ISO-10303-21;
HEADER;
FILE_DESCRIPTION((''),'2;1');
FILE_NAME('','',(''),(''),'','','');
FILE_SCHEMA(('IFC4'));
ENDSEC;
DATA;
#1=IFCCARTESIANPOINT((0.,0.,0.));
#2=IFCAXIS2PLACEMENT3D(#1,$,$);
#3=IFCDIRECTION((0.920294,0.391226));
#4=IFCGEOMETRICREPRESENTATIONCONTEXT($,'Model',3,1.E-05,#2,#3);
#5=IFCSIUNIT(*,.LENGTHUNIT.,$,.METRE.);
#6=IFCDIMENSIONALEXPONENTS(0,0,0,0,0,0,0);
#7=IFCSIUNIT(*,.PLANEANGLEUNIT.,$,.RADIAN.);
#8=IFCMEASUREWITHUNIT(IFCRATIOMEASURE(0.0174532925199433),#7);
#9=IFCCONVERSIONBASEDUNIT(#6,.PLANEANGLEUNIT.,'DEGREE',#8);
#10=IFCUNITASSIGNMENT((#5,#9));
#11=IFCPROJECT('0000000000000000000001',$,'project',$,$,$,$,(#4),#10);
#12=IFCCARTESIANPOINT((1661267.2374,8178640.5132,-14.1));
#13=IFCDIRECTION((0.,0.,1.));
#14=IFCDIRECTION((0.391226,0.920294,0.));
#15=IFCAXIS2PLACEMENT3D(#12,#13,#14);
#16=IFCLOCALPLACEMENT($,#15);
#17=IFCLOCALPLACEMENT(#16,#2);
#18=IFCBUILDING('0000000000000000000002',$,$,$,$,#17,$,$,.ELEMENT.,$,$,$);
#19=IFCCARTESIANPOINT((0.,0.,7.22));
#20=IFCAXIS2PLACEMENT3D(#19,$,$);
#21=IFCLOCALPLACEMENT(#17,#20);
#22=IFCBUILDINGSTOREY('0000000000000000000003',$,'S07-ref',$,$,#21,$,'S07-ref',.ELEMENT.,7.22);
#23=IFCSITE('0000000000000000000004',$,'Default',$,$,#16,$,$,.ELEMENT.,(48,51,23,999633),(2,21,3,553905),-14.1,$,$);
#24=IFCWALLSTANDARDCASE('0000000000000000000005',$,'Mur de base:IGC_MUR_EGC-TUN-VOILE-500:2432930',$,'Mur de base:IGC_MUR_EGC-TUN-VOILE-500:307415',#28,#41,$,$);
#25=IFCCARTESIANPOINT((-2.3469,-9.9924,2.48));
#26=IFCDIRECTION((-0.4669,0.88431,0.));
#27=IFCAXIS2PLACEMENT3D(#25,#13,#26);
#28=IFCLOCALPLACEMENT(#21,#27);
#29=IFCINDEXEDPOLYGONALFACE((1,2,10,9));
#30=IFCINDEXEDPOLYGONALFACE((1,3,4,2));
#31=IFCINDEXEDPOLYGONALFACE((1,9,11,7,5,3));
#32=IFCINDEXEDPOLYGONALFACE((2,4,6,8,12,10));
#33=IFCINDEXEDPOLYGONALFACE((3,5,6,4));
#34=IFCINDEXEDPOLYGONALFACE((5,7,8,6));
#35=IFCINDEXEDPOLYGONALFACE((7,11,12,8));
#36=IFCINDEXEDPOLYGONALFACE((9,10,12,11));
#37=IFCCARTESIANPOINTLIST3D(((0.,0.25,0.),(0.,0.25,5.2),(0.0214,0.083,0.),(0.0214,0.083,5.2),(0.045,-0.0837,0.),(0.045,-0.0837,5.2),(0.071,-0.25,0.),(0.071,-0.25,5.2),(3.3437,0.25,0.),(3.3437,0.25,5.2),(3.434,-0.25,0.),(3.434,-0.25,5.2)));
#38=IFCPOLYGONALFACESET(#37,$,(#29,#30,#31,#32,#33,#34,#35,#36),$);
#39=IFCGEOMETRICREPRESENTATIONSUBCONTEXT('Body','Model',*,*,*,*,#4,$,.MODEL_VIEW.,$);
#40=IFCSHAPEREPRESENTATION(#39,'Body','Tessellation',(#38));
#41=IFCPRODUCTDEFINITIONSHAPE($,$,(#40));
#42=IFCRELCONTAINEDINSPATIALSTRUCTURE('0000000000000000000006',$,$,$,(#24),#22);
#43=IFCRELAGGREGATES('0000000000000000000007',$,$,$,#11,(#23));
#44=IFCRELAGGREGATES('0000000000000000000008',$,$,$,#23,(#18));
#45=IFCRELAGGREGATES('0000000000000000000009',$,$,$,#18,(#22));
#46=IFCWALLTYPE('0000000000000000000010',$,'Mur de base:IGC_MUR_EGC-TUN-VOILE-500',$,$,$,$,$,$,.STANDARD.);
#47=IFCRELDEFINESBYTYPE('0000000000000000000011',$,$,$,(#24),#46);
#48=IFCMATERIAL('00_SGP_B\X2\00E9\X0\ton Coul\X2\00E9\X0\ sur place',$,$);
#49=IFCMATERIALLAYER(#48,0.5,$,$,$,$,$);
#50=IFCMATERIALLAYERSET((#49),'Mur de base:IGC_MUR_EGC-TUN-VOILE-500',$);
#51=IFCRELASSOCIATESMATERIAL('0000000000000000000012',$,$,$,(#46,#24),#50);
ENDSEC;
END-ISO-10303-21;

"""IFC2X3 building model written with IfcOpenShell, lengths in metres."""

from ifc_helpers import new_model, entity, si_unit, converted_unit, direction, frame, frame_2d, origin, place, context, subcontext, project, spatial, polyline, circle_curve, parameter, trimmed, segment, composite_curve, outline, extrude, clip, bounded_halfspace, material, layer, layer_set, layer_usage, type_object, element, save


model = new_model("IFC2X3")

# Units and contexts
model_context = context("Model", 3, precision=1e-05, world=origin(), true_north=direction((0.920294, 0.391226)))
body_context = subcontext(model_context, "Body", "Model", "MODEL_VIEW")
ifc_project = project(units=[si_unit("LENGTHUNIT", "METRE"), converted_unit("PLANEANGLEUNIT", "DEGREE", entity("IfcRatioMeasure", 0.0174532925199433), si_unit("PLANEANGLEUNIT", "RADIAN"), dimensions=[0, 0, 0, 0, 0, 0, 0])], contexts=[model_context])

# Site, building, storey
site_placement = place(None, frame((1661267.2374, 8178640.5132, -14.1), z_axis=(0.0, 0.0, 1.0), x_axis=(0.391226, 0.920294, 0.0)))
site = spatial("IfcSite", under=ifc_project, at=site_placement, Name="Default", CompositionType="ELEMENT", RefLatitude=(48, 51, 23, 999633), RefLongitude=(2, 21, 3, 553905), RefElevation=-14.1)
building_placement = place(site_placement, origin())
building = spatial("IfcBuilding", under=site, at=building_placement, CompositionType="ELEMENT")
storey_placement = place(building_placement, frame((0.0, 0.0, 7.22)))
storey = spatial("IfcBuildingStorey", under=building, at=storey_placement, Name="S07-ref", LongName="S07-ref", CompositionType="ELEMENT", Elevation=7.22)

# Shared definitions
ifc_material_1 = material(Name="00_SGP_Béton Coulé sur place")

# Wall
ifc_layer_1 = layer(ifc_material_1, 0.5)
ifc_layer_set_1 = layer_set([ifc_layer_1], Name="Mur de base:IGC_MUR_EGC-TUN-VOILE-500")
wall_type_1 = type_object("IfcWallType", Name="Mur de base:IGC_MUR_EGC-TUN-VOILE-500", PredefinedType="STANDARD", material=ifc_layer_set_1)
ifc_layer_usage_1 = layer_usage(ifc_layer_set_1, "AXIS2", "NEGATIVE", 0.25)
wall_1_placement = place(storey_placement, frame((-2.3469, -9.9924, 2.48), z_axis=(0.0, 0.0, 1.0), x_axis=(-0.4669, 0.88431, 0.0)))
element("IfcWallStandardCase", 1, at=wall_1_placement, inside=storey, type_object=wall_type_1, material=ifc_layer_usage_1, Name="Mur de base:IGC_MUR_EGC-TUN-VOILE-500:2432930", ObjectType="Mur de base:IGC_MUR_EGC-TUN-VOILE-500:307415", context=body_context, shape_type="Clipping", body=[
    clip(extrude(outline(composite_curve([segment(polyline([(0.071, -0.25), (3.434, -0.25)]), True, "CONTINUOUS"), segment(polyline([(3.434, -0.25), (3.3437, 0.25)]), True, "CONTINUOUS"), segment(polyline([(3.3437, 0.25), (3.3331, 0.25)]), True, "CONTINUOUS"), segment(polyline([(3.3331, 0.25), (0.0, 0.25)]), True, "CONTINUOUS"), segment(trimmed(circle_curve(frame_2d((12.2108, 1.7287), x_axis=(-0.4669, -0.88431)), 12.3), [parameter(304.738207)], [parameter(307.090833)], True, "PARAMETER"), True, "CONTINUOUS")], self_intersect=False)), origin(), (0.0, 0.0, 1.0), 5.2), bounded_halfspace(frame((3.434, -0.25, 5.2), z_axis=(-0.984076, -0.177746, 0.0), x_axis=(0.0, 0.0, -1.0)), True, frame((3.434, -0.25, 5.2), z_axis=(-0.984076, -0.177746, 0.0), x_axis=(0.0, 0.0, -1.0)), polyline([(0.0, 0.0), (0.0, -0.5081), (5.2, -0.5081), (5.2, 0.0), (0.0, 0.0)]))),
])

save(model, "model.ifc")
